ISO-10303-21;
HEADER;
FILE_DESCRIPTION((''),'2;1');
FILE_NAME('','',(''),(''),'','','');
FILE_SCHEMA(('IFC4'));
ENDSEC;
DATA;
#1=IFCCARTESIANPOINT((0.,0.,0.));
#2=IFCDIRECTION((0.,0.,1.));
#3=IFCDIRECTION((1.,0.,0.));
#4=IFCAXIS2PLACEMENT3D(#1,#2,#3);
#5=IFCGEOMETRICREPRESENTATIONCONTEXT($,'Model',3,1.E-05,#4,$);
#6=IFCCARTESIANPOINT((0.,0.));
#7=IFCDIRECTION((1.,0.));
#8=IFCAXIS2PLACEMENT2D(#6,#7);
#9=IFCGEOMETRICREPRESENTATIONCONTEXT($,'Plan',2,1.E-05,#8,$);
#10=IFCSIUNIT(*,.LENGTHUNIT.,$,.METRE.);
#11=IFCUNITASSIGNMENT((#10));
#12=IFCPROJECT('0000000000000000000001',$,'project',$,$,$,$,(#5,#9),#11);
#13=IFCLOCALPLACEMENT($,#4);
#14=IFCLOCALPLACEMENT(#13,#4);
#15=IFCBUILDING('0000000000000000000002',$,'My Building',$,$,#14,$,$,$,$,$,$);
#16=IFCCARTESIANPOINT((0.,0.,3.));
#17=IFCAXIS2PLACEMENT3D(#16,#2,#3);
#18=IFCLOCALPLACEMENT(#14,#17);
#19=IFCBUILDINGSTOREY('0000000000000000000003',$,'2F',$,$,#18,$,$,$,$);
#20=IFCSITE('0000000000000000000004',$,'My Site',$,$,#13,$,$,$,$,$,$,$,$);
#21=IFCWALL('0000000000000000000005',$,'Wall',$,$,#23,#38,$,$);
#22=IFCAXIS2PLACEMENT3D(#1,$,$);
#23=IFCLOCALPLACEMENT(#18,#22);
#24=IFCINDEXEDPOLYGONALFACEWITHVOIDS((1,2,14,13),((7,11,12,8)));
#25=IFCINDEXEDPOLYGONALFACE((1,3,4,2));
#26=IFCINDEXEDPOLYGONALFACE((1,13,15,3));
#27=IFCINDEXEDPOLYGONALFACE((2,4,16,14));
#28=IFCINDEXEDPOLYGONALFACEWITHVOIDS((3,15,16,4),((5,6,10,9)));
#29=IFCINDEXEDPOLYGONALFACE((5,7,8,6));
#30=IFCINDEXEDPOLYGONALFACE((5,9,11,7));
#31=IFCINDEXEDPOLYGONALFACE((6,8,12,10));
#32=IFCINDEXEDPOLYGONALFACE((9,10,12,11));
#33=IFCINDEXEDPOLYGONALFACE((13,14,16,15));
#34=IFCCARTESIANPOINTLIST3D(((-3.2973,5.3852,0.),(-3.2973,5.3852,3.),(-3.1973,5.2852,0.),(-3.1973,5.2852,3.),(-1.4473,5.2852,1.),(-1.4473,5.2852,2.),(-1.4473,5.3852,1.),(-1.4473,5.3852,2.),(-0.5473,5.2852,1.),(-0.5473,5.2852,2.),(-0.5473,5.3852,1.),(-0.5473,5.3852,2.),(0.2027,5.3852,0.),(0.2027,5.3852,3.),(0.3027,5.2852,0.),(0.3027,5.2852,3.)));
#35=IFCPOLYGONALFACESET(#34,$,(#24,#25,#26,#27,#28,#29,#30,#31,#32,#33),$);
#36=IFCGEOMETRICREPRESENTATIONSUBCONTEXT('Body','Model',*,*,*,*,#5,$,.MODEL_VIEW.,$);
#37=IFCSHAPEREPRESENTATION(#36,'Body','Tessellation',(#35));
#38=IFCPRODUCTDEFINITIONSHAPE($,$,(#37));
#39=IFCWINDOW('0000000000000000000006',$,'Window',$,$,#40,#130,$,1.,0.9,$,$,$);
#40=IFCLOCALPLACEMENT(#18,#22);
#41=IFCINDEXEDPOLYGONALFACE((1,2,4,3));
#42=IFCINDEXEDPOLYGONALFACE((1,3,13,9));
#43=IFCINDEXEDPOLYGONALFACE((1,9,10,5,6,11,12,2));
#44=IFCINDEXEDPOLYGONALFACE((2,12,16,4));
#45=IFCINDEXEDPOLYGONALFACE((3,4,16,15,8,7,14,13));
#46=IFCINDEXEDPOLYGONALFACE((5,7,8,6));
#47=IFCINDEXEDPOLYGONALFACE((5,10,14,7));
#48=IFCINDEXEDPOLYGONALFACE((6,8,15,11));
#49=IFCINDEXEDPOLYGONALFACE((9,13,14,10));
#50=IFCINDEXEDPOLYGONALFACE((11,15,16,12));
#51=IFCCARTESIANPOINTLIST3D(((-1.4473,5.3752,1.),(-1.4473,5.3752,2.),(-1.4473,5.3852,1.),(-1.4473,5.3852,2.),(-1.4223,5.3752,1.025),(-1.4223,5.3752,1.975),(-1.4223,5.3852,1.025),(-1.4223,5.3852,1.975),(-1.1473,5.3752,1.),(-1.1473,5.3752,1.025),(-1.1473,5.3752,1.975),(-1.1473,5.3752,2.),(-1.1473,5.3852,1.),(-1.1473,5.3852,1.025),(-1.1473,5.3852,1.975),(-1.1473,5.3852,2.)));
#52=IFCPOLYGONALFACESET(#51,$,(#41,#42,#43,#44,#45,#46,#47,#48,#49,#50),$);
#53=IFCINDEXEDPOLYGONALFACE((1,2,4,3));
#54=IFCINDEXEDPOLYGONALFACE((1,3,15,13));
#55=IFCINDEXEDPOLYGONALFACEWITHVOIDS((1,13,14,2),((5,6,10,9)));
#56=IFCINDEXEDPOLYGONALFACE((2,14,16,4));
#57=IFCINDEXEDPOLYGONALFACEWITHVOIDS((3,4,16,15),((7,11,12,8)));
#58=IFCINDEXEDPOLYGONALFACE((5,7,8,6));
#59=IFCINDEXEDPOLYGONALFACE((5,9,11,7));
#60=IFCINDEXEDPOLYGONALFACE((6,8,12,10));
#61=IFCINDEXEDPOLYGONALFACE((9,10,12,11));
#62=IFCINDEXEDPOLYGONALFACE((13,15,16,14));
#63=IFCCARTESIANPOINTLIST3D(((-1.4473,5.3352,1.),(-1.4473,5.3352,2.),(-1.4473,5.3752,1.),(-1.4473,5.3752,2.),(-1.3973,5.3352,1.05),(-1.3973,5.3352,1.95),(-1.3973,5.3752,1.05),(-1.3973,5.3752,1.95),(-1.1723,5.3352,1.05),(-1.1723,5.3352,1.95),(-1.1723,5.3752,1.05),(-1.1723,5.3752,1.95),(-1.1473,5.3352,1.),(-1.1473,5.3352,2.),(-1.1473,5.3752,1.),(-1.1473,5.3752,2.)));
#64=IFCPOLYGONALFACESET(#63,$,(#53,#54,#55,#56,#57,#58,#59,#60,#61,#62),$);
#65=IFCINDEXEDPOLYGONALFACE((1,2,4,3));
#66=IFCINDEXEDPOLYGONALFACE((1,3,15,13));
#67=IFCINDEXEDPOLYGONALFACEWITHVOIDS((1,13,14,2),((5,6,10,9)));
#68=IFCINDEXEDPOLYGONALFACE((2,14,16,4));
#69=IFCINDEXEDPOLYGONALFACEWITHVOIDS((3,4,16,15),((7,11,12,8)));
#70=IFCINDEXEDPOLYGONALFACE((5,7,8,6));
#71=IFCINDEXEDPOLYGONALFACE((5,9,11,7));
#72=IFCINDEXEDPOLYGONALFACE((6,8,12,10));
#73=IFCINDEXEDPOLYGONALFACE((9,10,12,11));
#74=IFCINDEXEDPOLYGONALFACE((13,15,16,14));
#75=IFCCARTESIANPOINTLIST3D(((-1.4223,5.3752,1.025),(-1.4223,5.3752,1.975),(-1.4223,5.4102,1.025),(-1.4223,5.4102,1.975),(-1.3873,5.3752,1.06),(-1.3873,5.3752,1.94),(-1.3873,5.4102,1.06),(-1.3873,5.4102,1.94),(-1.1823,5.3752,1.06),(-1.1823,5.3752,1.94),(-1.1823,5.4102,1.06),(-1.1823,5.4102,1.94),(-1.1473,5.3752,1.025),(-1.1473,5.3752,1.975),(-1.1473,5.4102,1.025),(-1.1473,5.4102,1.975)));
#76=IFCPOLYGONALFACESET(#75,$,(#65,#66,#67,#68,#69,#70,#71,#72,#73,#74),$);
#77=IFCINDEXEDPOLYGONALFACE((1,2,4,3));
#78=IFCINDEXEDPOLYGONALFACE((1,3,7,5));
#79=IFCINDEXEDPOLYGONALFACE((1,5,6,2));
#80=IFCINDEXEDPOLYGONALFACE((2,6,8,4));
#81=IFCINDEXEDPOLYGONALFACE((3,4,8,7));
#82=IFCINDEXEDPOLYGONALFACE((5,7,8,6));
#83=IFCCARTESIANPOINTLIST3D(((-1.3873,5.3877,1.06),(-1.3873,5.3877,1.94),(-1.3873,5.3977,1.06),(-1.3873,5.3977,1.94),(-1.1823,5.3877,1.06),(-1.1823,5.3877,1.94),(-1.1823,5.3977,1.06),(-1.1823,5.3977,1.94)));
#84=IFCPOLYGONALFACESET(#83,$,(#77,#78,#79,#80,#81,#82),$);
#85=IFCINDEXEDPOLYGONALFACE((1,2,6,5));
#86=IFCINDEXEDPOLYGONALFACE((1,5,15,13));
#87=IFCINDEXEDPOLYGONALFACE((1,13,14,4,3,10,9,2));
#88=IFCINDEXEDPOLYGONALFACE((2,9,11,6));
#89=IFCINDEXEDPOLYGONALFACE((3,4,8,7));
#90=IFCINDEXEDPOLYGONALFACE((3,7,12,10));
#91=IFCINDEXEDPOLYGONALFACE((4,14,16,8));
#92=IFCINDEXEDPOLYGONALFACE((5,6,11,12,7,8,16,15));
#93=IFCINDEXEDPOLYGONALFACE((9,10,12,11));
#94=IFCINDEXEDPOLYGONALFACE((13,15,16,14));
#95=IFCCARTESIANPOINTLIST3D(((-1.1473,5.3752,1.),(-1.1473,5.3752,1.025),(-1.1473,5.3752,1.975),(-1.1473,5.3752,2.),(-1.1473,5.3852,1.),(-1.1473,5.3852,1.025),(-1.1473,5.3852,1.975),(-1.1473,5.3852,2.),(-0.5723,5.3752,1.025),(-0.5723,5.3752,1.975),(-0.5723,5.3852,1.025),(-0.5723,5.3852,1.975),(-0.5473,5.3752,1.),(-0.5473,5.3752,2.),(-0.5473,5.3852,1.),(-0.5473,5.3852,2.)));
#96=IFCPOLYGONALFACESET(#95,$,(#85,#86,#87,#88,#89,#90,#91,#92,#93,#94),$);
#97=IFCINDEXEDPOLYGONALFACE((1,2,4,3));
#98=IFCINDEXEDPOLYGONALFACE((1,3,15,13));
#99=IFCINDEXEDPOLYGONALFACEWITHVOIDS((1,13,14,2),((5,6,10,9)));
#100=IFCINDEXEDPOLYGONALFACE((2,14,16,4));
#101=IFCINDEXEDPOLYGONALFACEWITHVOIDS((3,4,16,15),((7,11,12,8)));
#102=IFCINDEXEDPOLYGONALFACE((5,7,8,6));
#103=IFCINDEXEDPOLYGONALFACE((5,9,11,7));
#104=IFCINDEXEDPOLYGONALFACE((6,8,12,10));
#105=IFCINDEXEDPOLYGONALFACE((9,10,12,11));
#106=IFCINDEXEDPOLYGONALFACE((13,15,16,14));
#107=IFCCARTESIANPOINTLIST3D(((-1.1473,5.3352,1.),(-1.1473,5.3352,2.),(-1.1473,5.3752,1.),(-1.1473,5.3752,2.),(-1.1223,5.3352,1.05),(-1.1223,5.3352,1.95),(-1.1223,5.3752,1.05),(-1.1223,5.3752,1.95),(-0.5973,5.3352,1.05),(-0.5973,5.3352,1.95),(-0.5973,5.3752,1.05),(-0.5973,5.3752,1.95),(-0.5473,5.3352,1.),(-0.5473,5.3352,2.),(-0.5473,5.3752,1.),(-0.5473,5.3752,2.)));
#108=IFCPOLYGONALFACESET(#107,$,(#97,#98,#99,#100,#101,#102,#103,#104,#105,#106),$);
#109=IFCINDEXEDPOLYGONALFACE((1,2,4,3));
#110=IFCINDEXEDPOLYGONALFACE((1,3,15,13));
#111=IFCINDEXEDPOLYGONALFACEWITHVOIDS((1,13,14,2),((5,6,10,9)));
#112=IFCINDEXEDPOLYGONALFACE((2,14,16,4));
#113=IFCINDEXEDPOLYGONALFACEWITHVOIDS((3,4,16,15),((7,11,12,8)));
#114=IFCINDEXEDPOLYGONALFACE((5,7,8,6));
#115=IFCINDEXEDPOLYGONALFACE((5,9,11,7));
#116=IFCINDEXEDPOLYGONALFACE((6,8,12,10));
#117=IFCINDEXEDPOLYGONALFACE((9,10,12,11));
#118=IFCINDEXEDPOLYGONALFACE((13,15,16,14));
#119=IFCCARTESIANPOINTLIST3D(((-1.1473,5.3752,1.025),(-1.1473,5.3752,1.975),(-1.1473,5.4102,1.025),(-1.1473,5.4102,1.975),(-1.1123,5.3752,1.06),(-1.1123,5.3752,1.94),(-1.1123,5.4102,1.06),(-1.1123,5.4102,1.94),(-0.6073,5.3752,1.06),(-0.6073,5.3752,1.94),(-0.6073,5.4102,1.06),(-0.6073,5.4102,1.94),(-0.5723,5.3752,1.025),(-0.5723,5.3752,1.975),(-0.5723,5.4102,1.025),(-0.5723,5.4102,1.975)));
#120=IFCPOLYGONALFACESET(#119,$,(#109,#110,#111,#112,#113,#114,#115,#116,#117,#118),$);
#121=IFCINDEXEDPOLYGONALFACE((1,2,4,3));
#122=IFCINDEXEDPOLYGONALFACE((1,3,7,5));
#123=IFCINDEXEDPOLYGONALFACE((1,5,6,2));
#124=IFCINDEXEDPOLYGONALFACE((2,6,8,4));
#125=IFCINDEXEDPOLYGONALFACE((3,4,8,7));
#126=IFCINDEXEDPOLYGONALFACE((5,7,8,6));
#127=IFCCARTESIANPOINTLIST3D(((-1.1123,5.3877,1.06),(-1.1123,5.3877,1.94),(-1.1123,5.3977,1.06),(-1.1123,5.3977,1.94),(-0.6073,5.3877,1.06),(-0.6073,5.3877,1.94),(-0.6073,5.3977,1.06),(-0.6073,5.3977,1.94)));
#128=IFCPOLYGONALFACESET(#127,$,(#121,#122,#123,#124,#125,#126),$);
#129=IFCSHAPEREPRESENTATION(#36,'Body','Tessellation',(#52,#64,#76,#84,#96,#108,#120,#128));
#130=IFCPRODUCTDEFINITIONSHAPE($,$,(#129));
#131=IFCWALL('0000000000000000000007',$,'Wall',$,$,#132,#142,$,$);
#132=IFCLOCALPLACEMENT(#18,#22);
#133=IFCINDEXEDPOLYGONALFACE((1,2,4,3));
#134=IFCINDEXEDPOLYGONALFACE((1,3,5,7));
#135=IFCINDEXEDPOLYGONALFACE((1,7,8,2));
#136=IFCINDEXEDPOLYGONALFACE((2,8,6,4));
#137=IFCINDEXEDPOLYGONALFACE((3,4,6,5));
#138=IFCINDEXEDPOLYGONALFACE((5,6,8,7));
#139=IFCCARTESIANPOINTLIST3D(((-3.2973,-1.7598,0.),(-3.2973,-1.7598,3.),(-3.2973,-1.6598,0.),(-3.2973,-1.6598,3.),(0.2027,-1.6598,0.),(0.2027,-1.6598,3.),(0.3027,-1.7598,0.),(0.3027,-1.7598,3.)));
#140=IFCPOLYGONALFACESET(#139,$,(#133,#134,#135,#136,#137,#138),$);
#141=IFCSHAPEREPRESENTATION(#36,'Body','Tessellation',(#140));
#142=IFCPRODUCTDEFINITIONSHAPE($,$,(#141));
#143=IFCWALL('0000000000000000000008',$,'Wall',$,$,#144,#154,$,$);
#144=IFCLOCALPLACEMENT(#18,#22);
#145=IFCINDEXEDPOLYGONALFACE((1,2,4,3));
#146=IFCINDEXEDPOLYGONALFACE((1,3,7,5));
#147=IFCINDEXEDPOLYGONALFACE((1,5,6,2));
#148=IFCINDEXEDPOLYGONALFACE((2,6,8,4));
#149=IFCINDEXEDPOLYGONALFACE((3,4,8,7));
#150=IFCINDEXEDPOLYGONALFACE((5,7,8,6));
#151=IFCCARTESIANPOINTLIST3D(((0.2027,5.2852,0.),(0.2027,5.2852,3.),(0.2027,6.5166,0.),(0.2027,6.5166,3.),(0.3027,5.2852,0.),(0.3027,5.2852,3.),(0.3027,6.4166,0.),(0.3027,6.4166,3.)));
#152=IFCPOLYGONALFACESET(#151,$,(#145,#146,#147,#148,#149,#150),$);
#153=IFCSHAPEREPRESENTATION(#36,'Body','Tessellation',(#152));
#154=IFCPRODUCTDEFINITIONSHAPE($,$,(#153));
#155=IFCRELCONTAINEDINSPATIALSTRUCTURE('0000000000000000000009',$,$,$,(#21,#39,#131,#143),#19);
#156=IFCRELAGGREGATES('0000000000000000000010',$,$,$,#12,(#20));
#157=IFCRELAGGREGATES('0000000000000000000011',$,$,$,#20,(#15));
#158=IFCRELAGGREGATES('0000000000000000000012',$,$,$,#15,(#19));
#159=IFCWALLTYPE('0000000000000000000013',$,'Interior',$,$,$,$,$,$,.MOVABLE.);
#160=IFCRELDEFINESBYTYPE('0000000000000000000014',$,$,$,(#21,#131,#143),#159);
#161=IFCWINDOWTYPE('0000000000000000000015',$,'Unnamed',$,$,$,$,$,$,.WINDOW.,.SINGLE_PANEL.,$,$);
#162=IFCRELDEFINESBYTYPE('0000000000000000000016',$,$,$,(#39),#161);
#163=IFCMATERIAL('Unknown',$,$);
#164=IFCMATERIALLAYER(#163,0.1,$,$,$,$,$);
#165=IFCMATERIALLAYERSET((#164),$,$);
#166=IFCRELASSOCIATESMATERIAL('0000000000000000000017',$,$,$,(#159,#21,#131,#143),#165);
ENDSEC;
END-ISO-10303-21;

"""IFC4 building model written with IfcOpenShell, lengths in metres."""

from ifc_helpers import new_model, entity, si_unit, frame, origin_with_axes, origin_2d_with_axis, place, context, subcontext, project, spatial, line, indexed_curve, outline, extrude, shape, source, transform, mapped, material, layer, layer_set, layer_usage, type_object, type_shapes, element, fill, save


model = new_model("IFC4")

# Units and contexts
model_context = context("Model", 3, precision=1e-05, world=origin_with_axes())
plan_context = context("Plan", 2, precision=1e-05, world=origin_2d_with_axis())
body_context_1 = subcontext(model_context, "Body", "Model", "MODEL_VIEW")
body_context_2 = subcontext(plan_context, "Body", "Plan", "PLAN_VIEW")
ifc_project = project(units=[si_unit("LENGTHUNIT", "METRE")], contexts=[model_context, plan_context])

# Site, building, storey
site_placement = place(None, origin_with_axes())
site = spatial("IfcSite", under=ifc_project, at=site_placement, Name="My Site")
building_placement = place(site_placement, origin_with_axes())
building = spatial("IfcBuilding", under=site, at=building_placement, Name="My Building")
storey_placement = place(building_placement, frame((0.0, 0.0, 3.0), z_axis=(0.0, 0.0, 1.0), x_axis=(1.0, 0.0, 0.0)))
storey = spatial("IfcBuildingStorey", under=building, at=storey_placement, Name="2F")

# Shared definitions
ifc_material = material(Name="Unknown")

# Shared definitions
ifc_layer_1 = layer(ifc_material, 0.1)
ifc_layer_set_1 = layer_set([ifc_layer_1])
wall_type = type_object("IfcWallType", Name="Interior", PredefinedType="MOVABLE", material=ifc_layer_set_1)

# Wall, opening, window
ifc_layer_usage_1 = layer_usage(ifc_layer_set_1, "AXIS2", "POSITIVE", 0.0)
wall_1_placement = place(storey_placement, frame((0.2027, 5.3852, 0.0), z_axis=(0.0, 0.0, 1.0), x_axis=(-1.0, 0.0, 0.0)))
wall_1 = element("IfcWall", 1, at=wall_1_placement, inside=storey, type_object=wall_type, material=ifc_layer_usage_1, Name="Wall", context=body_context_1, shape_type="SweptSolid", body=[
    extrude(outline(indexed_curve([(0.0, 0.0), (-0.1, 0.1), (3.4, 0.1), (3.5, 0.0)], segments=[line(1, 2, 3, 4, 1)])), origin_with_axes(), (0.0, 0.0, 1.0), 3.0),
])
shared_shape_1 = source(origin_with_axes(), body_context_1, "Body", "SweptSolid", [
    extrude(outline(indexed_curve([(0.0, 0.0), (0.9, 0.0), (0.9, 1.0), (0.0, 1.0)], segments=[line(1, 2, 3, 4, 1)])), frame((0.0, -0.6, 0.0), z_axis=(0.0, -1.0, 0.0), x_axis=(1.0, 0.0, 0.0)), (0.0, 0.0, -1.0), 1.2),
])
opening_1_placement = place(wall_1_placement, frame((1.65, 0.1, 1.0), z_axis=(0.0, 0.0, 1.0), x_axis=(-1.0, 0.0, 0.0)))
opening_1 = element("IfcOpeningElement", 2, at=opening_1_placement, cuts=wall_1, PredefinedType="OPENING", context=body_context_1, shape_type="MappedRepresentation", body=[
    mapped(shared_shape_1, transform((0.0, 0.0, 0.0), x_axis=(1.0, 0.0, 0.0), y_axis=(0.0, 1.0, 0.0), z_axis=(0.0, 0.0, 1.0), scale=1.0)),
])
window_type = type_object("IfcWindowType", Name="Unnamed", PartitioningType="SINGLE_PANEL", PredefinedType="WINDOW")
shared_shape_2 = source(origin_with_axes(), body_context_1, "Body", "SweptSolid", [
    extrude(outline(indexed_curve([(0.3, 0.0), (0.0, 0.0), (0.0, 1.0), (0.3, 1.0), (0.3, 0.975), (0.025, 0.975), (0.025, 0.025), (0.3, 0.025)], segments=[line(1, 2, 3, 4, 5, 6, 7, 8, 1)])), frame((0.0, 0.09, 0.0), z_axis=(0.0, -1.0, 0.0), x_axis=(1.0, 0.0, 0.0)), (0.0, 0.0, -1.0), 0.01),
    extrude(outline(indexed_curve([(0.0, 0.0), (0.3, 0.0), (0.3, 1.0), (0.0, 1.0)], segments=[line(1, 2, 3, 4, 1)]), holes=[indexed_curve([(0.05, 0.05), (0.275, 0.05), (0.275, 0.95), (0.05, 0.95)], segments=[line(1, 2, 3, 4, 1)])]), frame((0.0, 0.05, 0.0), z_axis=(0.0, -1.0, 0.0), x_axis=(1.0, 0.0, 0.0)), (0.0, 0.0, -1.0), 0.04),
    extrude(outline(indexed_curve([(0.0, 0.0), (0.275, 0.0), (0.275, 0.95), (0.0, 0.95)], segments=[line(1, 2, 3, 4, 1)]), holes=[indexed_curve([(0.035, 0.035), (0.24, 0.035), (0.24, 0.915), (0.035, 0.915)], segments=[line(1, 2, 3, 4, 1)])]), frame((0.025, 0.09, 0.025), z_axis=(0.0, -1.0, 0.0), x_axis=(1.0, 0.0, 0.0)), (0.0, 0.0, -1.0), 0.035),
    extrude(outline(indexed_curve([(0.035, 0.035), (0.24, 0.035), (0.24, 0.915), (0.035, 0.915)], segments=[line(1, 2, 3, 4, 1)])), frame((0.025, 0.1025, 0.025), z_axis=(0.0, -1.0, 0.0), x_axis=(1.0, 0.0, 0.0)), (0.0, 0.0, -1.0), 0.01),
    extrude(outline(indexed_curve([(0.0, 1.0), (0.6, 1.0), (0.6, 0.0), (0.0, 0.0), (0.0, 0.025), (0.575, 0.025), (0.575, 0.975), (0.0, 0.975)], segments=[line(1, 2, 3, 4, 5, 6, 7, 8, 1)])), frame((0.3, 0.09, 0.0), z_axis=(0.0, -1.0, 0.0), x_axis=(1.0, 0.0, 0.0)), (0.0, 0.0, -1.0), 0.01),
    extrude(outline(indexed_curve([(0.0, 0.0), (0.6, 0.0), (0.6, 1.0), (0.0, 1.0)], segments=[line(1, 2, 3, 4, 1)]), holes=[indexed_curve([(0.025, 0.05), (0.55, 0.05), (0.55, 0.95), (0.025, 0.95)], segments=[line(1, 2, 3, 4, 1)])]), frame((0.3, 0.05, 0.0), z_axis=(0.0, -1.0, 0.0), x_axis=(1.0, 0.0, 0.0)), (0.0, 0.0, -1.0), 0.04),
    extrude(outline(indexed_curve([(0.0, 0.0), (0.575, 0.0), (0.575, 0.95), (0.0, 0.95)], segments=[line(1, 2, 3, 4, 1)]), holes=[indexed_curve([(0.035, 0.035), (0.54, 0.035), (0.54, 0.915), (0.035, 0.915)], segments=[line(1, 2, 3, 4, 1)])]), frame((0.3, 0.09, 0.025), z_axis=(0.0, -1.0, 0.0), x_axis=(1.0, 0.0, 0.0)), (0.0, 0.0, -1.0), 0.035),
    extrude(outline(indexed_curve([(0.035, 0.035), (0.54, 0.035), (0.54, 0.915), (0.035, 0.915)], segments=[line(1, 2, 3, 4, 1)])), frame((0.3, 0.1025, 0.025), z_axis=(0.0, -1.0, 0.0), x_axis=(1.0, 0.0, 0.0)), (0.0, 0.0, -1.0), 0.01),
])
shared_shape_3 = source(origin_with_axes(), body_context_2, "Body", "Curve2D", [
    entity("IfcIndexedPolyCurve", entity("IfcCartesianPointList2D", [[0.05, 0.05], [0.275, 0.05]])),
    entity("IfcIndexedPolyCurve", entity("IfcCartesianPointList2D", [[0.0, 0.1], [0.025, 0.1], [0.025, 0.09], [0.05, 0.09], [0.05, 0.05], [0.0, 0.05]]), [entity("IfcLineIndex", [1, 2, 3, 4, 5, 6, 1])]),
    entity("IfcIndexedPolyCurve", entity("IfcCartesianPointList2D", [[0.3, 0.1], [0.3, 0.1], [0.3, 0.09], [0.275, 0.09], [0.275, 0.05], [0.3, 0.05]])),
    entity("IfcIndexedPolyCurve", entity("IfcCartesianPointList2D", [[0.025, 0.09], [0.06, 0.09], [0.06, 0.125], [0.025, 0.125]]), [entity("IfcLineIndex", [1, 2, 3, 4, 1])]),
    entity("IfcIndexedPolyCurve", entity("IfcCartesianPointList2D", [[0.3, 0.09], [0.265, 0.09], [0.265, 0.125], [0.3, 0.125]]), [entity("IfcLineIndex", [1, 2, 3, 4, 1])]),
    entity("IfcIndexedPolyCurve", entity("IfcCartesianPointList2D", [[0.06, 0.09], [0.265, 0.09]])),
    entity("IfcIndexedPolyCurve", entity("IfcCartesianPointList2D", [[0.06, 0.125], [0.265, 0.125]])),
    entity("IfcIndexedPolyCurve", entity("IfcCartesianPointList2D", [[0.06, 0.1075], [0.265, 0.1075]])),
    entity("IfcIndexedPolyCurve", entity("IfcCartesianPointList2D", [[0.325, 0.05], [0.85, 0.05]])),
    entity("IfcIndexedPolyCurve", entity("IfcCartesianPointList2D", [[0.3, 0.1], [0.3, 0.1], [0.3, 0.09], [0.325, 0.09], [0.325, 0.05], [0.3, 0.05]])),
    entity("IfcIndexedPolyCurve", entity("IfcCartesianPointList2D", [[0.9, 0.1], [0.875, 0.1], [0.875, 0.09], [0.85, 0.09], [0.85, 0.05], [0.9, 0.05]]), [entity("IfcLineIndex", [1, 2, 3, 4, 5, 6, 1])]),
    entity("IfcIndexedPolyCurve", entity("IfcCartesianPointList2D", [[0.3, 0.09], [0.335, 0.09], [0.335, 0.125], [0.3, 0.125]]), [entity("IfcLineIndex", [1, 2, 3, 4, 1])]),
    entity("IfcIndexedPolyCurve", entity("IfcCartesianPointList2D", [[0.875, 0.09], [0.84, 0.09], [0.84, 0.125], [0.875, 0.125]]), [entity("IfcLineIndex", [1, 2, 3, 4, 1])]),
    entity("IfcIndexedPolyCurve", entity("IfcCartesianPointList2D", [[0.335, 0.09], [0.84, 0.09]])),
    entity("IfcIndexedPolyCurve", entity("IfcCartesianPointList2D", [[0.335, 0.125], [0.84, 0.125]])),
    entity("IfcIndexedPolyCurve", entity("IfcCartesianPointList2D", [[0.335, 0.1075], [0.84, 0.1075]])),
])
type_shapes(window_type, [shared_shape_2, shared_shape_3])
window_1_placement = place(opening_1_placement, frame((0.0, 0.0, 0.0), z_axis=(0.0, 0.0, 1.0), x_axis=(1.0, 0.0, 0.0)))
window_1 = element("IfcWindow", 3, at=window_1_placement, inside=storey, type_object=window_type, Name="Window", OverallHeight=1.0, OverallWidth=0.9, shapes=[
    shape(body_context_1, "Body", "MappedRepresentation", [mapped(shared_shape_2, transform((0.0, 0.0, 0.0), x_axis=(1.0, 0.0, 0.0), y_axis=(0.0, 1.0, 0.0), z_axis=(0.0, 0.0, 1.0), scale=1.0))]),
    shape(body_context_2, "Body", "MappedRepresentation", [mapped(shared_shape_3, transform((0.0, 0.0, 0.0), x_axis=(1.0, 0.0, 0.0), y_axis=(0.0, 1.0, 0.0), z_axis=(0.0, 0.0, 1.0), scale=1.0))]),
])
fill(opening_1, window_1)

# Walls
ifc_layer_usage_2 = layer_usage(ifc_layer_set_1, "AXIS2", "POSITIVE", 0.0)
wall_2_placement = place(storey_placement, frame((-3.2973, -1.7598, 0.0), z_axis=(0.0, 0.0, 1.0), x_axis=(1.0, 0.0, 0.0)))
element("IfcWall", 4, at=wall_2_placement, inside=storey, type_object=wall_type, material=ifc_layer_usage_2, Name="Wall", context=body_context_1, shape_type="SweptSolid", body=[
    extrude(outline(indexed_curve([(0.0, 0.0), (0.0, 0.1), (3.5, 0.1), (3.6, 0.0)], segments=[line(1, 2, 3, 4, 1)])), origin_with_axes(), (0.0, 0.0, 1.0), 3.0),
])
ifc_layer_usage_3 = layer_usage(ifc_layer_set_1, "AXIS2", "POSITIVE", 0.0)
wall_3_placement = place(storey_placement, frame((0.3027, 5.2852, 0.0), z_axis=(0.0, 0.0, 1.0), x_axis=(0.0, 1.0, 0.0)))
element("IfcWall", 5, at=wall_3_placement, inside=storey, type_object=wall_type, material=ifc_layer_usage_3, Name="Wall", context=body_context_1, shape_type="SweptSolid", body=[
    extrude(outline(indexed_curve([(0.0, 0.0), (0.0, 0.1), (1.2314, 0.1), (1.1314, 0.0)], segments=[line(1, 2, 3, 4, 1)])), origin_with_axes(), (0.0, 0.0, 1.0), 3.0),
])

save(model, "model.ifc")
